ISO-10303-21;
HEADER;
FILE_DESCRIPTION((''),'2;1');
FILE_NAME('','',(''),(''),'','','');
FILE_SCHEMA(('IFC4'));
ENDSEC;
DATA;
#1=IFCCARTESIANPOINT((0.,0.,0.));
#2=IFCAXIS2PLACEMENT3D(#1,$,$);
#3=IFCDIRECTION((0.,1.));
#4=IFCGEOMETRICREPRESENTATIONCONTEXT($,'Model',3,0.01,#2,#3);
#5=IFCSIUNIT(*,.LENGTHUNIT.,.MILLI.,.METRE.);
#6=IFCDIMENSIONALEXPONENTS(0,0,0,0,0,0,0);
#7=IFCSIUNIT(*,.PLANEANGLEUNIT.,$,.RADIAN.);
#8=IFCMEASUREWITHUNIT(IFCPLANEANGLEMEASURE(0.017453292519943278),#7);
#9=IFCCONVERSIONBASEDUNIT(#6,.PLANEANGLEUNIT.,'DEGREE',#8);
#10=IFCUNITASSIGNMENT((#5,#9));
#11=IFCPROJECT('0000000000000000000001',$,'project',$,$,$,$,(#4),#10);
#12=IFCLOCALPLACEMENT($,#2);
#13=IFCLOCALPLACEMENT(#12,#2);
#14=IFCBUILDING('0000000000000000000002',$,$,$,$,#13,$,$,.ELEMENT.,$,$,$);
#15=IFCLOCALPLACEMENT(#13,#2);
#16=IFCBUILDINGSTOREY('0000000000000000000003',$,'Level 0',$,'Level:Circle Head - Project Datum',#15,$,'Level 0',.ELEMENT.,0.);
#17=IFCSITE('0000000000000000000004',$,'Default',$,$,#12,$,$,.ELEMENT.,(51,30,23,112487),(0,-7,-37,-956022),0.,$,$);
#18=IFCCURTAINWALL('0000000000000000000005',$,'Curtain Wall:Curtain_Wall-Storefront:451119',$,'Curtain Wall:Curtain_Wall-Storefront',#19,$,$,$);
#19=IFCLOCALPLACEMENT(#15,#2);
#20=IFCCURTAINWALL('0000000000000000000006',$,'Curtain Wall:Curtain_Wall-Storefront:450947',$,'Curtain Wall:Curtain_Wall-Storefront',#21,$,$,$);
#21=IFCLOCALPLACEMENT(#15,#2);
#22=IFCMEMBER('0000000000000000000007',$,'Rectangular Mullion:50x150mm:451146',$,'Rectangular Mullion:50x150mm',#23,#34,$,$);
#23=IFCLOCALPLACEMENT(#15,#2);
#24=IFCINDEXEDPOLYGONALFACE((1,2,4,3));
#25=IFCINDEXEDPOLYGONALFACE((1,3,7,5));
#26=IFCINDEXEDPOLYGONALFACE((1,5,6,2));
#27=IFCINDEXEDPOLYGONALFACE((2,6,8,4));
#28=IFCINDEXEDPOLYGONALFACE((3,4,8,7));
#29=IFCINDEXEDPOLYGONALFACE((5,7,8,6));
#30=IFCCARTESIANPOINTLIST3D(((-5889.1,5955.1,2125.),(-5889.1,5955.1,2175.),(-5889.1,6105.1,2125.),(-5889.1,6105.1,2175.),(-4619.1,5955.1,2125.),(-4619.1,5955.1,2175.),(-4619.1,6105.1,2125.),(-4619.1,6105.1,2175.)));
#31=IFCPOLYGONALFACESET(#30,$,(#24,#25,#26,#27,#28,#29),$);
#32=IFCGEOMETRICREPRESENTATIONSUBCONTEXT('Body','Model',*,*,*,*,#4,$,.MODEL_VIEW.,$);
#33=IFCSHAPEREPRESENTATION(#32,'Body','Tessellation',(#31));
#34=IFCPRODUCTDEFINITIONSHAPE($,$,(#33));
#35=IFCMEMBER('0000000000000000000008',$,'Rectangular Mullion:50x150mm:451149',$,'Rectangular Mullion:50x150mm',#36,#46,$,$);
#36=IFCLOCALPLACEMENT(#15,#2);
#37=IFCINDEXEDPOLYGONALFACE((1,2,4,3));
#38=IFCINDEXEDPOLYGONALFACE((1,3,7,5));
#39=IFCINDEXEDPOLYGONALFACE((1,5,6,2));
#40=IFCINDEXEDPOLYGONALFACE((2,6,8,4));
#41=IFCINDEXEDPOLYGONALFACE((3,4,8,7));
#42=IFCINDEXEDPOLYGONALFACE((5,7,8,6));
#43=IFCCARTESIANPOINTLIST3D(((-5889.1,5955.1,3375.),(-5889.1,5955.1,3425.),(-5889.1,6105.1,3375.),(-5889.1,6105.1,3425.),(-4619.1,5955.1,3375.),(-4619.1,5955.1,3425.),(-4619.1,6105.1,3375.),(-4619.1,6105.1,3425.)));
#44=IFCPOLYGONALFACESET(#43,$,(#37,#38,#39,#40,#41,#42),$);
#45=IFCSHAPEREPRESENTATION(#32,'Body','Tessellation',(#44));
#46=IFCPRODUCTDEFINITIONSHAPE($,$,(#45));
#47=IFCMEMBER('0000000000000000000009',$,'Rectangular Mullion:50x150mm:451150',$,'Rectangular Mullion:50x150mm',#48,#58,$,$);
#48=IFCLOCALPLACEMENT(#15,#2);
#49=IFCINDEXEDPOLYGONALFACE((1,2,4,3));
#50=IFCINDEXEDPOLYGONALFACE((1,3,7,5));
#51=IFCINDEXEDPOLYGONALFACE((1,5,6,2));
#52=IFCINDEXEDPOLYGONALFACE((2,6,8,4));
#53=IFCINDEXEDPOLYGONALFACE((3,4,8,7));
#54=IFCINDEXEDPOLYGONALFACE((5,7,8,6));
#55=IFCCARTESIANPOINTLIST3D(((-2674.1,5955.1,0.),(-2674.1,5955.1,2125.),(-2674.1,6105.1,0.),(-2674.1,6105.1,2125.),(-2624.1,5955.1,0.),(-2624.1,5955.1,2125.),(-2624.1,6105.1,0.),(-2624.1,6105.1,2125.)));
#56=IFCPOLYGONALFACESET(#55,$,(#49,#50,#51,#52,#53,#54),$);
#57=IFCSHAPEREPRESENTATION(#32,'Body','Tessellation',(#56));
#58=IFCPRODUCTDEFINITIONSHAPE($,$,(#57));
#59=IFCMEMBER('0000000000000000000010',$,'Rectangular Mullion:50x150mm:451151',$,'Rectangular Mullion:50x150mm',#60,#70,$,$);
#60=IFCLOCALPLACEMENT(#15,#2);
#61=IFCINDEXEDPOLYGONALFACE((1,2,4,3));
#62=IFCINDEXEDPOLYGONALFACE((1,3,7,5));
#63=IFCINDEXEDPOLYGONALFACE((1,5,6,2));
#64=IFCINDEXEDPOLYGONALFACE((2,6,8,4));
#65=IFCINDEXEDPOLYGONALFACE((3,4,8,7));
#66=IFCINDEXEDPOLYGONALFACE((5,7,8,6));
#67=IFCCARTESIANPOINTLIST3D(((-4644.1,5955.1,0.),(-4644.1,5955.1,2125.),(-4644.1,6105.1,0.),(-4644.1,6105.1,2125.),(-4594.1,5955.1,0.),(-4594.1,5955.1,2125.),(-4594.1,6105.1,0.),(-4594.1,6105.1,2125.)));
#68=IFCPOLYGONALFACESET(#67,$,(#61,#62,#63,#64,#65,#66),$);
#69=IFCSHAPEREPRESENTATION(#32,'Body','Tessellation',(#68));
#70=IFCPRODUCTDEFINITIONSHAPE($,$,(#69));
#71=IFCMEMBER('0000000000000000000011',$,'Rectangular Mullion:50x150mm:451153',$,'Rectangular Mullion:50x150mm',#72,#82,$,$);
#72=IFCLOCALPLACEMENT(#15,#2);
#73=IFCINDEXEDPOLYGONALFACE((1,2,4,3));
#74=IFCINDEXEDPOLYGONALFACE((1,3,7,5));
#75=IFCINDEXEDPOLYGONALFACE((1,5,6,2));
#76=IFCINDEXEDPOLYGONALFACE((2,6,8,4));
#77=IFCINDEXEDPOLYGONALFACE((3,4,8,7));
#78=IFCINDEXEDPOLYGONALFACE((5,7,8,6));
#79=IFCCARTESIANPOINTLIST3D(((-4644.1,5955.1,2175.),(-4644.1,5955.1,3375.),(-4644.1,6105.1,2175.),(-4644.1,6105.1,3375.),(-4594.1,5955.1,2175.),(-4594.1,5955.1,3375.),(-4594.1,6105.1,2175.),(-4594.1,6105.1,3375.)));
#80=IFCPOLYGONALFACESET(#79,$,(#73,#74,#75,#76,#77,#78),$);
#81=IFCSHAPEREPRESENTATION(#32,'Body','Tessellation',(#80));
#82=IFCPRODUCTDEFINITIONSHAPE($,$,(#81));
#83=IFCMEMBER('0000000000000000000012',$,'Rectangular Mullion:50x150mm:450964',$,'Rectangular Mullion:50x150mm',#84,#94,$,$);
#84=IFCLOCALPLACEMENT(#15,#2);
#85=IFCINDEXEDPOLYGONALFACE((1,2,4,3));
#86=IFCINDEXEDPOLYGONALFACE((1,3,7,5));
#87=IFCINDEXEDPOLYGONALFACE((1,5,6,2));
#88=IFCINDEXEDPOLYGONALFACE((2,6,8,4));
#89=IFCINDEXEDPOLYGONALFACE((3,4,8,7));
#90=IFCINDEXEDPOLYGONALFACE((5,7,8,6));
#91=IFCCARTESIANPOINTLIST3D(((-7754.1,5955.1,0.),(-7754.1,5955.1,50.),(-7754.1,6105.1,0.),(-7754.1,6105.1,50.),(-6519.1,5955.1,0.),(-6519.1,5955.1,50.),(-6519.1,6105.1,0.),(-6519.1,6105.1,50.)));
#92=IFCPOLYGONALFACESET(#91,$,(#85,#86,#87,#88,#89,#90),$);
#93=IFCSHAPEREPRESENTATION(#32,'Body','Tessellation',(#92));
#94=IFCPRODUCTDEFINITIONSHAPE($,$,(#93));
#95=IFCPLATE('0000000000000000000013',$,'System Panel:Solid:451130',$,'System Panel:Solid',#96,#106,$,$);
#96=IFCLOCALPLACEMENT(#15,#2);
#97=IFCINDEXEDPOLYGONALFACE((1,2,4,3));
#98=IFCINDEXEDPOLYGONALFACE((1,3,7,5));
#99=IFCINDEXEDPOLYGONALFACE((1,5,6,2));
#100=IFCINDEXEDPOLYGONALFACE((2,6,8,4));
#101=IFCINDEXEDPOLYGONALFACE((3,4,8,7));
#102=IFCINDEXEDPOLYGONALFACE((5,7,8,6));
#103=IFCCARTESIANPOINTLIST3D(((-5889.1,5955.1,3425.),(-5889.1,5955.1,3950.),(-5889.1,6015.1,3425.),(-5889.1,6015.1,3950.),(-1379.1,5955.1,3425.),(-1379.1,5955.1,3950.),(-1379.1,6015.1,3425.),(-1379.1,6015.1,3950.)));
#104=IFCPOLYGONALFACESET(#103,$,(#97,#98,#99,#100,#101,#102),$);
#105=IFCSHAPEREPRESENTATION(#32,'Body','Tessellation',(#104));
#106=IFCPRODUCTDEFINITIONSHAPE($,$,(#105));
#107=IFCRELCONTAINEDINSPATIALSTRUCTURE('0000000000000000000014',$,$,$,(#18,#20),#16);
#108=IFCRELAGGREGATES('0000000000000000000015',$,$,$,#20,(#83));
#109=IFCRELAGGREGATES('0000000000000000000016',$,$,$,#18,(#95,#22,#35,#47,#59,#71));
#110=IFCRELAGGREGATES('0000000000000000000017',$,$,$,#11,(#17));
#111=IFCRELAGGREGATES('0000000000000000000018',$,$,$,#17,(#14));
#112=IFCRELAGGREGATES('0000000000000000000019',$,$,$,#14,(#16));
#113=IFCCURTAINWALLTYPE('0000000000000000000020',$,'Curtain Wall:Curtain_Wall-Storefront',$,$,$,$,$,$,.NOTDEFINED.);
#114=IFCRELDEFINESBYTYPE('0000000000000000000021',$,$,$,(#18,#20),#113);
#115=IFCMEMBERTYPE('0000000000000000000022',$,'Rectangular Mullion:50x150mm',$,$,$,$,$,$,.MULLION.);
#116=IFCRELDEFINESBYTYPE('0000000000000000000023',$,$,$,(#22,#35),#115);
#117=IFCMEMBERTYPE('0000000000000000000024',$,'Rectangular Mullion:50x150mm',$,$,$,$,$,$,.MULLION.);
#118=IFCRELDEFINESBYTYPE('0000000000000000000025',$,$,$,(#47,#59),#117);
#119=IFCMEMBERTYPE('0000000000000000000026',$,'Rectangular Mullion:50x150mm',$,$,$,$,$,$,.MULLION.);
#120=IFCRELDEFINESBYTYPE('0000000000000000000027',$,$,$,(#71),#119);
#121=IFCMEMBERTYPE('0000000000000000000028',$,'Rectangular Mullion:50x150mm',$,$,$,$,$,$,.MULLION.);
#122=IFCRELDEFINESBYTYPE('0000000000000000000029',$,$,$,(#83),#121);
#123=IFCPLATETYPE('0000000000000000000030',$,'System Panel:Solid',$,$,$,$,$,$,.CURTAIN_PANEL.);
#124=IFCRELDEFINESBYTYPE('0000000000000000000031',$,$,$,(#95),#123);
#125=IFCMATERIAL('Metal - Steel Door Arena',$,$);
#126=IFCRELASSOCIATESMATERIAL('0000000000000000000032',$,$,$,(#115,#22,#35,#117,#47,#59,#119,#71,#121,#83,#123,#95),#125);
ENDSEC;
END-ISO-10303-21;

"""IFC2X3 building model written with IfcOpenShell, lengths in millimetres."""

from ifc_helpers import new_model, entity, si_unit, converted_unit, direction, frame, frame_2d, origin, origin_2d_with_axis, place, context, subcontext, project, spatial, rectangle, extrude, source, transform, mapped, material, type_object, type_shapes, element, aggregate, save


model = new_model("IFC2X3")

# Units and contexts
model_context = context("Model", 3, precision=0.01, world=origin(), true_north=direction((0.0, 1.0)))
body_context = subcontext(model_context, "Body", "Model", "MODEL_VIEW")
ifc_project = project(units=[si_unit("LENGTHUNIT", "METRE", prefix="MILLI"), converted_unit("PLANEANGLEUNIT", "DEGREE", entity("IfcPlaneAngleMeasure", 0.017453292519943278), si_unit("PLANEANGLEUNIT", "RADIAN"), dimensions=[0, 0, 0, 0, 0, 0, 0])], contexts=[model_context])

# Site, building, storey
site_placement = place(None, origin())
site = spatial("IfcSite", under=ifc_project, at=site_placement, Name="Default", CompositionType="ELEMENT", RefLatitude=(51, 30, 23, 112487), RefLongitude=(0, -7, -37, -956022), RefElevation=0.0)
building_placement = place(site_placement, origin())
building = spatial("IfcBuilding", under=site, at=building_placement, CompositionType="ELEMENT")
storey_placement = place(building_placement, origin())
storey = spatial("IfcBuildingStorey", under=building, at=storey_placement, Name="Level 0", ObjectType="Level:Circle Head - Project Datum", LongName="Level 0", CompositionType="ELEMENT", Elevation=0.0)

# Curtain walls
curtain_wall_type = type_object("IfcCurtainWallType", Name="Curtain Wall:Curtain_Wall-Storefront", PredefinedType="NOTDEFINED")
curtain_wall_1_placement = place(storey_placement, origin())
curtain_wall_1 = element("IfcCurtainWall", 1, at=curtain_wall_1_placement, inside=storey, type_object=curtain_wall_type, Name="Curtain Wall:Curtain_Wall-Storefront:451119", ObjectType="Curtain Wall:Curtain_Wall-Storefront")
ifc_material_1 = material(Name="Metal - Steel Door Arena")
curtain_wall_2_placement = place(storey_placement, origin())
curtain_wall_2 = element("IfcCurtainWall", 2, at=curtain_wall_2_placement, inside=storey, type_object=curtain_wall_type, Name="Curtain Wall:Curtain_Wall-Storefront:450947", ObjectType="Curtain Wall:Curtain_Wall-Storefront")

# Members
member_type_1 = type_object("IfcMemberType", Name="Rectangular Mullion:50x150mm", PredefinedType="MULLION", material=ifc_material_1)
shared_shape_1 = source(origin(), body_context, "Body", "SweptSolid", [
    extrude(rectangle(XDim=50.0, YDim=150.0, at=origin_2d_with_axis()), frame((0.0, 0.0, -1270.0), z_axis=(0.0, 0.0, 1.0), x_axis=(-1.0, 0.0, 0.0)), (0.0, 0.0, 1.0), 1270.0),
])
type_shapes(member_type_1, [shared_shape_1])
member_1_placement = place(curtain_wall_1_placement, frame((-5889.1, 6030.1, 2150.0), z_axis=(-1.0, 0.0, 0.0), x_axis=(0.0, 0.0, 1.0)))
member_1 = element("IfcMember", 3, at=member_1_placement, type_object=member_type_1, material=ifc_material_1, Name="Rectangular Mullion:50x150mm:451146", ObjectType="Rectangular Mullion:50x150mm", context=body_context, shape_type="MappedRepresentation", body=[
    mapped(shared_shape_1, transform((0.0, 0.0, 0.0), scale=1.0)),
])
member_2_placement = place(curtain_wall_1_placement, frame((-5889.1, 6030.1, 3400.0), z_axis=(-1.0, 0.0, 0.0), x_axis=(0.0, 0.0, 1.0)))
member_2 = element("IfcMember", 4, at=member_2_placement, type_object=member_type_1, material=ifc_material_1, Name="Rectangular Mullion:50x150mm:451149", ObjectType="Rectangular Mullion:50x150mm", context=body_context, shape_type="MappedRepresentation", body=[
    mapped(shared_shape_1, transform((0.0, 0.0, 0.0), scale=1.0)),
])
member_type_2 = type_object("IfcMemberType", Name="Rectangular Mullion:50x150mm", PredefinedType="MULLION", material=ifc_material_1)
shared_shape_2 = source(origin(), body_context, "Body", "SweptSolid", [
    extrude(rectangle(XDim=50.0, YDim=150.0, at=origin_2d_with_axis()), frame((0.0, 0.0, -2125.0), z_axis=(0.0, 0.0, 1.0), x_axis=(-1.0, 0.0, 0.0)), (0.0, 0.0, 1.0), 2125.0),
])
type_shapes(member_type_2, [shared_shape_2])
member_3_placement = place(curtain_wall_1_placement, frame((-2649.1, 6030.1, 0.0), z_axis=(0.0, 0.0, -1.0), x_axis=(-1.0, 0.0, 0.0)))
member_3 = element("IfcMember", 5, at=member_3_placement, type_object=member_type_2, material=ifc_material_1, Name="Rectangular Mullion:50x150mm:451150", ObjectType="Rectangular Mullion:50x150mm", context=body_context, shape_type="MappedRepresentation", body=[
    mapped(shared_shape_2, transform((0.0, 0.0, 0.0), scale=1.0)),
])
member_4_placement = place(curtain_wall_1_placement, frame((-4619.1, 6030.1, 0.0), z_axis=(0.0, 0.0, -1.0), x_axis=(-1.0, 0.0, 0.0)))
member_4 = element("IfcMember", 6, at=member_4_placement, type_object=member_type_2, material=ifc_material_1, Name="Rectangular Mullion:50x150mm:451151", ObjectType="Rectangular Mullion:50x150mm", context=body_context, shape_type="MappedRepresentation", body=[
    mapped(shared_shape_2, transform((0.0, 0.0, 0.0), scale=1.0)),
])
member_type_3 = type_object("IfcMemberType", Name="Rectangular Mullion:50x150mm", PredefinedType="MULLION", material=ifc_material_1)
shared_shape_3 = source(origin(), body_context, "Body", "SweptSolid", [
    extrude(rectangle(XDim=50.0, YDim=150.0, at=origin_2d_with_axis()), frame((0.0, 0.0, -1200.0), z_axis=(0.0, 0.0, 1.0), x_axis=(-1.0, 0.0, 0.0)), (0.0, 0.0, 1.0), 1200.0),
])
type_shapes(member_type_3, [shared_shape_3])
member_5_placement = place(curtain_wall_1_placement, frame((-4619.1, 6030.1, 2175.0), z_axis=(0.0, 0.0, -1.0), x_axis=(-1.0, 0.0, 0.0)))
member_5 = element("IfcMember", 7, at=member_5_placement, type_object=member_type_3, material=ifc_material_1, Name="Rectangular Mullion:50x150mm:451153", ObjectType="Rectangular Mullion:50x150mm", context=body_context, shape_type="MappedRepresentation", body=[
    mapped(shared_shape_3, transform((0.0, 0.0, 0.0), scale=1.0)),
])
member_type_4 = type_object("IfcMemberType", Name="Rectangular Mullion:50x150mm", PredefinedType="MULLION", material=ifc_material_1)
shared_shape_4 = source(origin(), body_context, "Body", "SweptSolid", [
    extrude(rectangle(XDim=50.0, YDim=150.0, at=origin_2d_with_axis()), frame((-25.0, 0.0, -1235.0), z_axis=(0.0, 0.0, 1.0), x_axis=(-1.0, 0.0, 0.0)), (0.0, 0.0, 1.0), 1235.0),
])
type_shapes(member_type_4, [shared_shape_4])
member_6_placement = place(curtain_wall_2_placement, frame((-6519.1, 6030.1, 0.0), z_axis=(1.0, 0.0, 0.0), x_axis=(0.0, 0.0, -1.0)))
member_6 = element("IfcMember", 8, at=member_6_placement, type_object=member_type_4, material=ifc_material_1, Name="Rectangular Mullion:50x150mm:450964", ObjectType="Rectangular Mullion:50x150mm", context=body_context, shape_type="MappedRepresentation", body=[
    mapped(shared_shape_4, transform((0.0, 0.0, 0.0), scale=1.0)),
])
aggregate(curtain_wall_2, [member_6])

# Plate
plate_type_1 = type_object("IfcPlateType", Name="System Panel:Solid", PredefinedType="CURTAIN_PANEL", material=ifc_material_1)
shared_shape_5 = source(origin(), body_context, "Body", "SweptSolid", [
    extrude(rectangle(XDim=525.0, YDim=4510.0, at=frame_2d((0.0, 0.0), x_axis=(1.0, 0.0))), frame((0.0, 15.0, 262.5), z_axis=(0.0, 1.0, 0.0), x_axis=(0.0, 0.0, 1.0)), (0.0, 0.0, 1.0), 60.0),
])
type_shapes(plate_type_1, [shared_shape_5])
plate_1_placement = place(curtain_wall_1_placement, frame((-3634.1, 6030.1, 3425.0), z_axis=(0.0, 0.0, 1.0), x_axis=(-1.0, 0.0, 0.0)))
plate_1 = element("IfcPlate", 9, at=plate_1_placement, type_object=plate_type_1, material=ifc_material_1, Name="System Panel:Solid:451130", ObjectType="System Panel:Solid", context=body_context, shape_type="MappedRepresentation", body=[
    mapped(shared_shape_5, transform((0.0, 0.0, 0.0), scale=1.0)),
])
aggregate(curtain_wall_1, [plate_1, member_1, member_2, member_3, member_4, member_5])

save(model, "model.ifc")
